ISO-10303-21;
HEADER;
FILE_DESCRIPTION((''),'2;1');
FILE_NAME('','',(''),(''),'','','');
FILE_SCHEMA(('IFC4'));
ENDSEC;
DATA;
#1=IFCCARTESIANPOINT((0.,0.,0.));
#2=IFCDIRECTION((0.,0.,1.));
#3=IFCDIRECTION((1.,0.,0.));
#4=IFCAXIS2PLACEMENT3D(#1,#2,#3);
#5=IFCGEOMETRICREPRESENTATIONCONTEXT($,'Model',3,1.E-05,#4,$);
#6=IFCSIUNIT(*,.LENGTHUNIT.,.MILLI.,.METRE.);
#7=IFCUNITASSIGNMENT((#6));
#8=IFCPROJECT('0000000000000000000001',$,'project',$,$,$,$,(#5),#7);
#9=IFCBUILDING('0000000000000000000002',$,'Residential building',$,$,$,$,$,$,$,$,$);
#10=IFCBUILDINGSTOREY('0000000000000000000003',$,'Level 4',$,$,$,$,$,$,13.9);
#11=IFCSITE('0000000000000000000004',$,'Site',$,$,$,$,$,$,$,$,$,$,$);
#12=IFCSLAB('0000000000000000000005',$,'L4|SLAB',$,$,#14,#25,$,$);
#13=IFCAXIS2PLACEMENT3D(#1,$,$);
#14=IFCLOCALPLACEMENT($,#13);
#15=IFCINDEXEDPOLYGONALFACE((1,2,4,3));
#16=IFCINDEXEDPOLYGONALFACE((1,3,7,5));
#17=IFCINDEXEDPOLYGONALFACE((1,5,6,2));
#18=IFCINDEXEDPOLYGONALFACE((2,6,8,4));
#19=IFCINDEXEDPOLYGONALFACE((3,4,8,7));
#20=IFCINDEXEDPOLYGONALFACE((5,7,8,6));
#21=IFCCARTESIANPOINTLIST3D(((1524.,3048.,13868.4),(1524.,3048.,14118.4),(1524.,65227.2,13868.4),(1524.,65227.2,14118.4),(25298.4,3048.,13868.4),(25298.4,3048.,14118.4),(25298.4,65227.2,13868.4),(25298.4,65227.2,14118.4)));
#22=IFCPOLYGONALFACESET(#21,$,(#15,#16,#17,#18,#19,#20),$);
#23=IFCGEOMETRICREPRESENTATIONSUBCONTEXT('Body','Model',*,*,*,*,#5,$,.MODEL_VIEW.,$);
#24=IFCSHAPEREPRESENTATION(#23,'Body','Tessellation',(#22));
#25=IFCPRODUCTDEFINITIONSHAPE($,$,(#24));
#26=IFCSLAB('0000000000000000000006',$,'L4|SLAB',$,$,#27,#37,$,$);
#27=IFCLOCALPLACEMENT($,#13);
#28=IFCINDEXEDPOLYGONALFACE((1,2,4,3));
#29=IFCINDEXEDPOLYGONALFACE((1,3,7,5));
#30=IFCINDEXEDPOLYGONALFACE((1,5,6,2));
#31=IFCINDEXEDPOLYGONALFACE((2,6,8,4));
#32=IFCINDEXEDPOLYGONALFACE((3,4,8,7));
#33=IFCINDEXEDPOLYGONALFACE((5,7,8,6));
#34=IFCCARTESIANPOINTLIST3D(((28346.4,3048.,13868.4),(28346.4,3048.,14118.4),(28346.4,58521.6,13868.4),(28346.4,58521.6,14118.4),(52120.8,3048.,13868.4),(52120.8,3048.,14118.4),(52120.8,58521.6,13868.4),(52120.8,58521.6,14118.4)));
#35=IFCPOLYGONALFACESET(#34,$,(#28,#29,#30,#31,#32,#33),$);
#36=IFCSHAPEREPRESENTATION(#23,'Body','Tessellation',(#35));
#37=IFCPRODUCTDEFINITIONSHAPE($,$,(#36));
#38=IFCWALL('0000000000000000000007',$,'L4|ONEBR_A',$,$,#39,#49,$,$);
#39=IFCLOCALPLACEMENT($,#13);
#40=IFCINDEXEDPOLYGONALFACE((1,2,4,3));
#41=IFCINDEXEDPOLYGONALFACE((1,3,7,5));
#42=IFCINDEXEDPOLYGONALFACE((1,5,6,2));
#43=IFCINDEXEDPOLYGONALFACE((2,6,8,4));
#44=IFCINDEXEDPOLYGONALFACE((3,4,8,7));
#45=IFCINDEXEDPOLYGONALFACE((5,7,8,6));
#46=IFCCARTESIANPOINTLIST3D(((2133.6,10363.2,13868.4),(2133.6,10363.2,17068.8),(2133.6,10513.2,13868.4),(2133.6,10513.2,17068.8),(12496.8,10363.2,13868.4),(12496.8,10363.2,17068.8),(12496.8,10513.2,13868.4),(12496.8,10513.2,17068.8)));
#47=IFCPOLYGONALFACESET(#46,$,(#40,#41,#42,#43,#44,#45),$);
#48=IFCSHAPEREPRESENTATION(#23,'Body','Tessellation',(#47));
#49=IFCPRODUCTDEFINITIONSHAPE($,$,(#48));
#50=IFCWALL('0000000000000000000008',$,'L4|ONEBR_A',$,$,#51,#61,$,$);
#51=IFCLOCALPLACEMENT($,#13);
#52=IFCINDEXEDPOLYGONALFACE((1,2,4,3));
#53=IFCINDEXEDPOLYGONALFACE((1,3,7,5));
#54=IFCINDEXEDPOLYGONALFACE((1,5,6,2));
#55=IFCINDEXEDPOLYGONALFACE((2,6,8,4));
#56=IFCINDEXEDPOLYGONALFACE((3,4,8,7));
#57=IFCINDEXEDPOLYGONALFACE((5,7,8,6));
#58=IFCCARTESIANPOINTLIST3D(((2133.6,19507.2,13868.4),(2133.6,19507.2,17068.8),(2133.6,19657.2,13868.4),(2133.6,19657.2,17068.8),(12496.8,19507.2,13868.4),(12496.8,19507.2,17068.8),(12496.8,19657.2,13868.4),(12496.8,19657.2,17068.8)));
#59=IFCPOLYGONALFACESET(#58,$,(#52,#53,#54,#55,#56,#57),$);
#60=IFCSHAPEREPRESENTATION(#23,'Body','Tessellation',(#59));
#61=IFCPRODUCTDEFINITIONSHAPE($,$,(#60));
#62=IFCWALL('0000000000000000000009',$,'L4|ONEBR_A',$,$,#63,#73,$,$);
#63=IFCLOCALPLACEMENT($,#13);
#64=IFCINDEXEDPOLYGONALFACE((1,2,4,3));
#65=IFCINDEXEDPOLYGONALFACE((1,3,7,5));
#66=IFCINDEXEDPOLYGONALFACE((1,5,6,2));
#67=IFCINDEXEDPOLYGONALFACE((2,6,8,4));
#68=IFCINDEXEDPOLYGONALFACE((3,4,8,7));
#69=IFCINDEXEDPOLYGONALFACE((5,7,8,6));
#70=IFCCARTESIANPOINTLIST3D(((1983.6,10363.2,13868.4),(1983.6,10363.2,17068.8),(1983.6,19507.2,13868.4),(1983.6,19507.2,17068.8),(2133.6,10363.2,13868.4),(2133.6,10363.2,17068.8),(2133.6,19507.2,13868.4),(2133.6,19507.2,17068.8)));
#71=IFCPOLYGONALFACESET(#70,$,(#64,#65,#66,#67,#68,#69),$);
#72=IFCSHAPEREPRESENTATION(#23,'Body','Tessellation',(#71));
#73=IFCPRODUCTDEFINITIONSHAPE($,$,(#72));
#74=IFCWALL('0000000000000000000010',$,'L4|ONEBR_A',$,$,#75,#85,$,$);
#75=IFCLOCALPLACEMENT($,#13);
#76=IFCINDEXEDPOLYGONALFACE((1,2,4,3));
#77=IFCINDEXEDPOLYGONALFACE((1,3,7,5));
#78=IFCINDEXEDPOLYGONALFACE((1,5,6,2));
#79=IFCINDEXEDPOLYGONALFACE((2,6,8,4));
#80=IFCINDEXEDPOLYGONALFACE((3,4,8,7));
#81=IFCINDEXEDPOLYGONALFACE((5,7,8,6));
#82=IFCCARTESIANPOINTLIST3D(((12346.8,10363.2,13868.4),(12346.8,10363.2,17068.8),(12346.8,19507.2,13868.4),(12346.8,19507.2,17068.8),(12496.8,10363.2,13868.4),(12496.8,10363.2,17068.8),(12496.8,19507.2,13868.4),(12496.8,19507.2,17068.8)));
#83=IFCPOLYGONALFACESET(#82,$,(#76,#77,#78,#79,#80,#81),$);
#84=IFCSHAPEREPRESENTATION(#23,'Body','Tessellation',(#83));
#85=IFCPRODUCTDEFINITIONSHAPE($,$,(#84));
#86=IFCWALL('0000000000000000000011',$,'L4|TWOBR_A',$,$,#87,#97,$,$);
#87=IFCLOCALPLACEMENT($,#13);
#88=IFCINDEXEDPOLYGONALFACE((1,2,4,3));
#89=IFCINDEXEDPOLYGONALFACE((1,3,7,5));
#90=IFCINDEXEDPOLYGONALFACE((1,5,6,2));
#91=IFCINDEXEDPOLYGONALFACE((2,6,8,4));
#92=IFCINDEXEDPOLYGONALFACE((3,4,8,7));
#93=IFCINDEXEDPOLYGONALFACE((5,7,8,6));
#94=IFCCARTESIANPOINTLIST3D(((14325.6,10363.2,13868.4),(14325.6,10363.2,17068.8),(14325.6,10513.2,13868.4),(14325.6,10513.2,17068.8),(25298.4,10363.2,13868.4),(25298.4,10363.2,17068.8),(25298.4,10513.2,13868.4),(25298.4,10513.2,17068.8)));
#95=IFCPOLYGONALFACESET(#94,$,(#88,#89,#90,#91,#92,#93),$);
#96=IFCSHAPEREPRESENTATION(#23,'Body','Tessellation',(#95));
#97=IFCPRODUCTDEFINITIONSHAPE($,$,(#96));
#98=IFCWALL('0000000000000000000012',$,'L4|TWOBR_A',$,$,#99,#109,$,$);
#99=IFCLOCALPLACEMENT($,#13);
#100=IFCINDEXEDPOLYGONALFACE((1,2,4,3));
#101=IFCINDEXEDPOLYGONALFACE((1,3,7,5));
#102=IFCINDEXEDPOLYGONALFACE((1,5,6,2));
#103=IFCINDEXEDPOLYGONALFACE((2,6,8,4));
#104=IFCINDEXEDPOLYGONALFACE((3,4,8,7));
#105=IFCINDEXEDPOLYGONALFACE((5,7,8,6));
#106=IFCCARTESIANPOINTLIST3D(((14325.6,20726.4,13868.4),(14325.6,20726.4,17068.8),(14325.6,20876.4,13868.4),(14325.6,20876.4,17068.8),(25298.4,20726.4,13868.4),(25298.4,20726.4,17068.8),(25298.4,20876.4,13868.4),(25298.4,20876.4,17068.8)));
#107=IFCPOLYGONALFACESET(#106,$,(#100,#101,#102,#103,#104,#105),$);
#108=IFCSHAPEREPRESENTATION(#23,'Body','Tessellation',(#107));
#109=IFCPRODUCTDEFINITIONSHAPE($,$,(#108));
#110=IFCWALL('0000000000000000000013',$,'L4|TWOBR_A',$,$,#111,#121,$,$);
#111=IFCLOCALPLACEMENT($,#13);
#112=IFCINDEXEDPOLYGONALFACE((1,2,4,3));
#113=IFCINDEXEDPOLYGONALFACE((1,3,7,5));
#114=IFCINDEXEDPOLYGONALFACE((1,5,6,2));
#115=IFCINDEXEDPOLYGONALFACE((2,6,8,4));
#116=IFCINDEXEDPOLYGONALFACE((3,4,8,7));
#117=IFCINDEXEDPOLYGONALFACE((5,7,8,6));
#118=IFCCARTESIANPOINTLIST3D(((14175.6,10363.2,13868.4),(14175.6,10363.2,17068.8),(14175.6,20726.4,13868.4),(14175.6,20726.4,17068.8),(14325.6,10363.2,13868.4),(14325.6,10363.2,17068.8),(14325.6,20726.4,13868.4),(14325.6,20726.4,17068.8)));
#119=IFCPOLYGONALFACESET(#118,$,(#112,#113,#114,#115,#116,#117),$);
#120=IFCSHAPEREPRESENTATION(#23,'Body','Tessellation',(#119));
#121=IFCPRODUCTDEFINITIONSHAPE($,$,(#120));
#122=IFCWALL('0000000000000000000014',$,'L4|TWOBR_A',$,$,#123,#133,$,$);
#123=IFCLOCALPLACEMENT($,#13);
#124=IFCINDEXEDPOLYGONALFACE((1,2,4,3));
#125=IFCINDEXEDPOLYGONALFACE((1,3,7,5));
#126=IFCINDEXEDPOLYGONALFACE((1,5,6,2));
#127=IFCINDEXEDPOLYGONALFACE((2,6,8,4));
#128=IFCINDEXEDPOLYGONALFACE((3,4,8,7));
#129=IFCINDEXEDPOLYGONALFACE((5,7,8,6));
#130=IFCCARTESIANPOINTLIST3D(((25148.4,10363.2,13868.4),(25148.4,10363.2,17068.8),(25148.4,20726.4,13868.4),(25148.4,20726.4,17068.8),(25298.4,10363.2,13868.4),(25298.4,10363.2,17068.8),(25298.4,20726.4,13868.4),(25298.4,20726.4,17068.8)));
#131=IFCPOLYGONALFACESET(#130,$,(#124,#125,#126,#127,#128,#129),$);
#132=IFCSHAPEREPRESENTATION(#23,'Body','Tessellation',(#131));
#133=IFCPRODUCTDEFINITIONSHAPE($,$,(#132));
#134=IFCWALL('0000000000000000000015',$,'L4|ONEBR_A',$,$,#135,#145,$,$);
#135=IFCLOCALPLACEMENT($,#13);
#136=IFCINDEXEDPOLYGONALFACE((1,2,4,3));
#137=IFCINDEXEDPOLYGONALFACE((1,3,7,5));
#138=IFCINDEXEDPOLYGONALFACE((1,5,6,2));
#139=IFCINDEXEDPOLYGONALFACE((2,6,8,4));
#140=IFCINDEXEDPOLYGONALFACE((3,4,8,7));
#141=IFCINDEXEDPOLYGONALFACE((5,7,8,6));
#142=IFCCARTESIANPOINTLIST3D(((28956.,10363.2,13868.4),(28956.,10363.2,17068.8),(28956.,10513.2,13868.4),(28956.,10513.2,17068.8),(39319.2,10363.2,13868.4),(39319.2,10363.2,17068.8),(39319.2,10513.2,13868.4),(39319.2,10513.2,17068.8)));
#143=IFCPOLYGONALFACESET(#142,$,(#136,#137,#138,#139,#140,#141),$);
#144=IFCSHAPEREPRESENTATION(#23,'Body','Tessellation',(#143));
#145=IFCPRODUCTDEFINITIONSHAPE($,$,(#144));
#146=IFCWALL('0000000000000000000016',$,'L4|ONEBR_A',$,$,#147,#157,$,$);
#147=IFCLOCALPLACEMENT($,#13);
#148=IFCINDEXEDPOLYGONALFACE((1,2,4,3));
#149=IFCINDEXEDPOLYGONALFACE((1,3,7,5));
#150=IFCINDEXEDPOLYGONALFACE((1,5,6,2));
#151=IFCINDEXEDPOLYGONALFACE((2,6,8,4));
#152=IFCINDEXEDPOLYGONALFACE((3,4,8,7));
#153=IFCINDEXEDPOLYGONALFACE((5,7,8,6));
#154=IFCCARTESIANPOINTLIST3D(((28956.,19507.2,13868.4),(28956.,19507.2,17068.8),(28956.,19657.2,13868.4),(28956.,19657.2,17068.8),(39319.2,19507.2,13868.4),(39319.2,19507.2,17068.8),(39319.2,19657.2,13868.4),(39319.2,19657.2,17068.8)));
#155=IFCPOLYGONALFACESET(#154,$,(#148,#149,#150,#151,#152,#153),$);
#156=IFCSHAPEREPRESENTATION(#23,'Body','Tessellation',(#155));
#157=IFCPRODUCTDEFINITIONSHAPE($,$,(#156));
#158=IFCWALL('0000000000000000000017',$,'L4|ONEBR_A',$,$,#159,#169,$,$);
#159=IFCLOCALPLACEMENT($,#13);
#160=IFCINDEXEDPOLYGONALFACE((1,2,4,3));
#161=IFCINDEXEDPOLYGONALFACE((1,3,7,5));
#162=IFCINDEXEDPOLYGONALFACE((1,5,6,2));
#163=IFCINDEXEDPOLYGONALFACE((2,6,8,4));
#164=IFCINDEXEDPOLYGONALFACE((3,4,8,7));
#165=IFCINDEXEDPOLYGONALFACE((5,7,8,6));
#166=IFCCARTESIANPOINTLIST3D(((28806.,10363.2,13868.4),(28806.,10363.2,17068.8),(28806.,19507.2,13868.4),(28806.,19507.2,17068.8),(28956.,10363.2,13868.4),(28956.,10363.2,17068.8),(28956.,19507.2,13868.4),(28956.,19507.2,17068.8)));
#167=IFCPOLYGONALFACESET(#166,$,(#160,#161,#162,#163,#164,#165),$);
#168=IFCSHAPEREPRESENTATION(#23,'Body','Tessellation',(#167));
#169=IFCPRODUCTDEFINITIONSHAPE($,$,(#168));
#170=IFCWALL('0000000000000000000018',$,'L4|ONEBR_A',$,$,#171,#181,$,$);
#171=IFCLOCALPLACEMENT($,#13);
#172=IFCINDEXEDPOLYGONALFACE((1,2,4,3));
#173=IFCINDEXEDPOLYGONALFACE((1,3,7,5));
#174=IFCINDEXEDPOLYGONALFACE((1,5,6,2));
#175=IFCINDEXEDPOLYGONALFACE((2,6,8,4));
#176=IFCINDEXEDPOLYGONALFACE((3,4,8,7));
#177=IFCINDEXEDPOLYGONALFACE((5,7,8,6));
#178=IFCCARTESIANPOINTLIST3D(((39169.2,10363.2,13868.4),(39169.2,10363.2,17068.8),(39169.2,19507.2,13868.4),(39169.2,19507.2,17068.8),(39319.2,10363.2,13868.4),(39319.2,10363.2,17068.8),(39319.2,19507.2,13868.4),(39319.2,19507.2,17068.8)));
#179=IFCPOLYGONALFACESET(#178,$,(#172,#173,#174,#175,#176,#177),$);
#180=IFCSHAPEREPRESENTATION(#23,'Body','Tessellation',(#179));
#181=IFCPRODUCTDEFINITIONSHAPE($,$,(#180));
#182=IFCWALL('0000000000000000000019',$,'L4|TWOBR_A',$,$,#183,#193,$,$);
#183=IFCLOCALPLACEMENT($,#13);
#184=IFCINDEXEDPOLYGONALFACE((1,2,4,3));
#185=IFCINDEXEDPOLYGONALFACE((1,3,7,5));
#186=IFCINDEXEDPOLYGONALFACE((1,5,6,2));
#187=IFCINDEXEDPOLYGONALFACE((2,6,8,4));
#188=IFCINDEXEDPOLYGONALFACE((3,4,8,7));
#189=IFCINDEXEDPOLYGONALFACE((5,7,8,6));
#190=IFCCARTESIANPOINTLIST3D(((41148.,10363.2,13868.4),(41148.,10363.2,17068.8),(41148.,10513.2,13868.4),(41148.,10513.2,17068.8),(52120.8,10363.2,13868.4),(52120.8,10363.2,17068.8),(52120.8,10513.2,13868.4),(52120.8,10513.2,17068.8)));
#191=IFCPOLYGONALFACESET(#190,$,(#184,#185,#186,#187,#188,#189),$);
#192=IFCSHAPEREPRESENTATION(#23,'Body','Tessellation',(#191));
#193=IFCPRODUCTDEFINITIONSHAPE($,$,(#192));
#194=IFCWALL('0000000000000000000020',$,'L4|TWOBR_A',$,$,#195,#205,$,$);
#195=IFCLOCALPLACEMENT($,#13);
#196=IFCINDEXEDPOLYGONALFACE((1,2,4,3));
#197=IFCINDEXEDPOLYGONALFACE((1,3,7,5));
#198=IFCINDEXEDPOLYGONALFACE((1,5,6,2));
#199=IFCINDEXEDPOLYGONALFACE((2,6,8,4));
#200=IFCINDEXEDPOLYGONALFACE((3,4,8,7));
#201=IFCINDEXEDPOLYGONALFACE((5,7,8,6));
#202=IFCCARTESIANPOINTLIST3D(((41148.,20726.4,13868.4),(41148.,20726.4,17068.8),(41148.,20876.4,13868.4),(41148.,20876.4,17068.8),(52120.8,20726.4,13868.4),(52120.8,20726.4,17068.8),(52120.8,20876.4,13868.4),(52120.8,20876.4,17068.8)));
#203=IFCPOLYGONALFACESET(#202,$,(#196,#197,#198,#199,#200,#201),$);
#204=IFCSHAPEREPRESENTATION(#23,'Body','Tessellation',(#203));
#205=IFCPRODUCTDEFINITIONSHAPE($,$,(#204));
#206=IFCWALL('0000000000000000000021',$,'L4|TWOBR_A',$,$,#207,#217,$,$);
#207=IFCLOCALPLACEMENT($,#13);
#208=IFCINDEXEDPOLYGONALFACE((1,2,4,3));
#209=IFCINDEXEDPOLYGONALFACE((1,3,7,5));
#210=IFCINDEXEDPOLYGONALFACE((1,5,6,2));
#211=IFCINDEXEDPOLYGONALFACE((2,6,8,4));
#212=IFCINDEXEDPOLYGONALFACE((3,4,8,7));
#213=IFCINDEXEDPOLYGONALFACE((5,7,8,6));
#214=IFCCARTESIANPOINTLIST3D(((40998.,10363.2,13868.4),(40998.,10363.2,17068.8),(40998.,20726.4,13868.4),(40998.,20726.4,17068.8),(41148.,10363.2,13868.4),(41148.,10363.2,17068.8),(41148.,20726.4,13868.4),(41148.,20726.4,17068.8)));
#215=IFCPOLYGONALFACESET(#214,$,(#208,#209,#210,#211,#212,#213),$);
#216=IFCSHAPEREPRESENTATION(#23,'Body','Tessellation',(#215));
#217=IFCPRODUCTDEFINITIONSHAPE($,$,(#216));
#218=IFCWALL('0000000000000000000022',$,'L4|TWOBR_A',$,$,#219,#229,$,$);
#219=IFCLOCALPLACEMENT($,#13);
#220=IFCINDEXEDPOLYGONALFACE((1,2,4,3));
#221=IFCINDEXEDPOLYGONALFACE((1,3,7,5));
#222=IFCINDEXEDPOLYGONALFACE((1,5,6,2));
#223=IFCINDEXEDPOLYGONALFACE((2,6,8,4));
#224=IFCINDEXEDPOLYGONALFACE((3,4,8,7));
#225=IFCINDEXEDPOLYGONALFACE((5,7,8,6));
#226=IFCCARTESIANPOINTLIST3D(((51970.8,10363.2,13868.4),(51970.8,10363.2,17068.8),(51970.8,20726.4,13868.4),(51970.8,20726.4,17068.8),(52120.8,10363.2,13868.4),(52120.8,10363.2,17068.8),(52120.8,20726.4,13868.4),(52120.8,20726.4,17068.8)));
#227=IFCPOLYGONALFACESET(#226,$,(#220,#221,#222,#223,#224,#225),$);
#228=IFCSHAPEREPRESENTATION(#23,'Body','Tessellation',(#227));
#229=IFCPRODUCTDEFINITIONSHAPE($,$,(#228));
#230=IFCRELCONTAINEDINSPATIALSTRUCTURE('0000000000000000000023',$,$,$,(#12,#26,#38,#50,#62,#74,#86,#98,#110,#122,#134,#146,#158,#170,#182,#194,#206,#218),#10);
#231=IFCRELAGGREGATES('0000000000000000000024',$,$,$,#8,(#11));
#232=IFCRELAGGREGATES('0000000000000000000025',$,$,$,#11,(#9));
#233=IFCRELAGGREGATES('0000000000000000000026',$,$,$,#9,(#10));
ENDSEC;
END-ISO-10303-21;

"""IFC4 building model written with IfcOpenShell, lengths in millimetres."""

from ifc_helpers import new_model, si_unit, frame, origin_with_axes, place, context, subcontext, project, spatial, indexed_curve, outline, extrude, element, save


model = new_model("IFC4")

# Units and contexts
model_context = context("Model", 3, precision=1e-05, world=origin_with_axes())
body_context = subcontext(model_context, "Body", "Model", "MODEL_VIEW")
ifc_project = project(units=[si_unit("LENGTHUNIT", "METRE", prefix="MILLI")], contexts=[model_context])

# Site, building, storey
site = spatial("IfcSite", under=ifc_project, Name="Site")
building = spatial("IfcBuilding", under=site, Name="Residential building")
storey = spatial("IfcBuildingStorey", under=building, Name="Level 4", Elevation=13.9)

# Slabs
slab_1_placement = place(None, frame((1524.0, 3048.0, 13868.4), z_axis=(0.0, 0.0, 1.0), x_axis=(1.0, 0.0, 0.0)))
element("IfcSlab", 1, at=slab_1_placement, inside=storey, Name="L4|SLAB", context=body_context, shape_type="SweptSolid", body=[
    extrude(outline(indexed_curve([(0.0, 0.0), (23774.4, 0.0), (23774.4, 62179.2), (0.0, 62179.2), (0.0, 0.0)])), None, (0.0, 0.0, 1.0), 250.0),
])
slab_2_placement = place(None, frame((28346.4, 3048.0, 13868.4), z_axis=(0.0, 0.0, 1.0), x_axis=(1.0, 0.0, 0.0)))
element("IfcSlab", 2, at=slab_2_placement, inside=storey, Name="L4|SLAB", context=body_context, shape_type="SweptSolid", body=[
    extrude(outline(indexed_curve([(0.0, 0.0), (23774.4, 0.0), (23774.4, 55473.6), (0.0, 55473.6), (0.0, 0.0)])), None, (0.0, 0.0, 1.0), 250.0),
])

# Walls
for number, where, z_axis, x_axis, name in (
    (3, (2133.6, 10363.2, 13868.4), (0.0, 0.0, 1.0), (1.0, 0.0, 0.0), "L4|ONEBR_A"),
    (4, (2133.6, 19507.2, 13868.4), (0.0, 0.0, 1.0), (1.0, 0.0, 0.0), "L4|ONEBR_A"),
):
    element("IfcWall", number, at=place(None, frame(where, z_axis=z_axis, x_axis=x_axis)), inside=storey, Name=name, context=body_context, shape_type="SweptSolid", body=[
        extrude(outline(indexed_curve([(0.0, 0.0), (0.0, 150.0), (10363.2, 150.0), (10363.2, 0.0), (0.0, 0.0)], self_intersect=False)), origin_with_axes(), (0.0, 0.0, 1.0), 3200.4),
    ])
for number, where, z_axis, x_axis, name in (
    (5, (2133.6, 10363.2, 13868.4), (0.0, 0.0, 1.0), (0.0, 1.0, 0.0), "L4|ONEBR_A"),
    (6, (12496.8, 10363.2, 13868.4), (0.0, 0.0, 1.0), (0.0, 1.0, 0.0), "L4|ONEBR_A"),
):
    element("IfcWall", number, at=place(None, frame(where, z_axis=z_axis, x_axis=x_axis)), inside=storey, Name=name, context=body_context, shape_type="SweptSolid", body=[
        extrude(outline(indexed_curve([(0.0, 0.0), (0.0, 150.0), (9144.0, 150.0), (9144.0, 0.0), (0.0, 0.0)], self_intersect=False)), origin_with_axes(), (0.0, 0.0, 1.0), 3200.4),
    ])
for number, where, z_axis, x_axis, name in (
    (7, (14325.6, 10363.2, 13868.4), (0.0, 0.0, 1.0), (1.0, 0.0, 0.0), "L4|TWOBR_A"),
    (8, (14325.6, 20726.4, 13868.4), (0.0, 0.0, 1.0), (1.0, 0.0, 0.0), "L4|TWOBR_A"),
):
    element("IfcWall", number, at=place(None, frame(where, z_axis=z_axis, x_axis=x_axis)), inside=storey, Name=name, context=body_context, shape_type="SweptSolid", body=[
        extrude(outline(indexed_curve([(0.0, 0.0), (0.0, 150.0), (10972.8, 150.0), (10972.8, 0.0), (0.0, 0.0)], self_intersect=False)), origin_with_axes(), (0.0, 0.0, 1.0), 3200.4),
    ])
for number, where, z_axis, x_axis, name in (
    (9, (14325.6, 10363.2, 13868.4), (0.0, 0.0, 1.0), (0.0, 1.0, 0.0), "L4|TWOBR_A"),
    (10, (25298.4, 10363.2, 13868.4), (0.0, 0.0, 1.0), (0.0, 1.0, 0.0), "L4|TWOBR_A"),
    (11, (28956.0, 10363.2, 13868.4), (0.0, 0.0, 1.0), (1.0, 0.0, 0.0), "L4|ONEBR_A"),
    (12, (28956.0, 19507.2, 13868.4), (0.0, 0.0, 1.0), (1.0, 0.0, 0.0), "L4|ONEBR_A"),
):
    element("IfcWall", number, at=place(None, frame(where, z_axis=z_axis, x_axis=x_axis)), inside=storey, Name=name, context=body_context, shape_type="SweptSolid", body=[
        extrude(outline(indexed_curve([(0.0, 0.0), (0.0, 150.0), (10363.2, 150.0), (10363.2, 0.0), (0.0, 0.0)], self_intersect=False)), origin_with_axes(), (0.0, 0.0, 1.0), 3200.4),
    ])
for number, where, z_axis, x_axis, name in (
    (13, (28956.0, 10363.2, 13868.4), (0.0, 0.0, 1.0), (0.0, 1.0, 0.0), "L4|ONEBR_A"),
    (14, (39319.2, 10363.2, 13868.4), (0.0, 0.0, 1.0), (0.0, 1.0, 0.0), "L4|ONEBR_A"),
):
    element("IfcWall", number, at=place(None, frame(where, z_axis=z_axis, x_axis=x_axis)), inside=storey, Name=name, context=body_context, shape_type="SweptSolid", body=[
        extrude(outline(indexed_curve([(0.0, 0.0), (0.0, 150.0), (9144.0, 150.0), (9144.0, 0.0), (0.0, 0.0)], self_intersect=False)), origin_with_axes(), (0.0, 0.0, 1.0), 3200.4),
    ])
for number, where, z_axis, x_axis, name in (
    (15, (41148.0, 10363.2, 13868.4), (0.0, 0.0, 1.0), (1.0, 0.0, 0.0), "L4|TWOBR_A"),
    (16, (41148.0, 20726.4, 13868.4), (0.0, 0.0, 1.0), (1.0, 0.0, 0.0), "L4|TWOBR_A"),
):
    element("IfcWall", number, at=place(None, frame(where, z_axis=z_axis, x_axis=x_axis)), inside=storey, Name=name, context=body_context, shape_type="SweptSolid", body=[
        extrude(outline(indexed_curve([(0.0, 0.0), (0.0, 150.0), (10972.8, 150.0), (10972.8, 0.0), (0.0, 0.0)], self_intersect=False)), origin_with_axes(), (0.0, 0.0, 1.0), 3200.4),
    ])
for number, where, z_axis, x_axis, name in (
    (17, (41148.0, 10363.2, 13868.4), (0.0, 0.0, 1.0), (0.0, 1.0, 0.0), "L4|TWOBR_A"),
    (18, (52120.8, 10363.2, 13868.4), (0.0, 0.0, 1.0), (0.0, 1.0, 0.0), "L4|TWOBR_A"),
):
    element("IfcWall", number, at=place(None, frame(where, z_axis=z_axis, x_axis=x_axis)), inside=storey, Name=name, context=body_context, shape_type="SweptSolid", body=[
        extrude(outline(indexed_curve([(0.0, 0.0), (0.0, 150.0), (10363.2, 150.0), (10363.2, 0.0), (0.0, 0.0)], self_intersect=False)), origin_with_axes(), (0.0, 0.0, 1.0), 3200.4),
    ])

save(model, "model.ifc")
